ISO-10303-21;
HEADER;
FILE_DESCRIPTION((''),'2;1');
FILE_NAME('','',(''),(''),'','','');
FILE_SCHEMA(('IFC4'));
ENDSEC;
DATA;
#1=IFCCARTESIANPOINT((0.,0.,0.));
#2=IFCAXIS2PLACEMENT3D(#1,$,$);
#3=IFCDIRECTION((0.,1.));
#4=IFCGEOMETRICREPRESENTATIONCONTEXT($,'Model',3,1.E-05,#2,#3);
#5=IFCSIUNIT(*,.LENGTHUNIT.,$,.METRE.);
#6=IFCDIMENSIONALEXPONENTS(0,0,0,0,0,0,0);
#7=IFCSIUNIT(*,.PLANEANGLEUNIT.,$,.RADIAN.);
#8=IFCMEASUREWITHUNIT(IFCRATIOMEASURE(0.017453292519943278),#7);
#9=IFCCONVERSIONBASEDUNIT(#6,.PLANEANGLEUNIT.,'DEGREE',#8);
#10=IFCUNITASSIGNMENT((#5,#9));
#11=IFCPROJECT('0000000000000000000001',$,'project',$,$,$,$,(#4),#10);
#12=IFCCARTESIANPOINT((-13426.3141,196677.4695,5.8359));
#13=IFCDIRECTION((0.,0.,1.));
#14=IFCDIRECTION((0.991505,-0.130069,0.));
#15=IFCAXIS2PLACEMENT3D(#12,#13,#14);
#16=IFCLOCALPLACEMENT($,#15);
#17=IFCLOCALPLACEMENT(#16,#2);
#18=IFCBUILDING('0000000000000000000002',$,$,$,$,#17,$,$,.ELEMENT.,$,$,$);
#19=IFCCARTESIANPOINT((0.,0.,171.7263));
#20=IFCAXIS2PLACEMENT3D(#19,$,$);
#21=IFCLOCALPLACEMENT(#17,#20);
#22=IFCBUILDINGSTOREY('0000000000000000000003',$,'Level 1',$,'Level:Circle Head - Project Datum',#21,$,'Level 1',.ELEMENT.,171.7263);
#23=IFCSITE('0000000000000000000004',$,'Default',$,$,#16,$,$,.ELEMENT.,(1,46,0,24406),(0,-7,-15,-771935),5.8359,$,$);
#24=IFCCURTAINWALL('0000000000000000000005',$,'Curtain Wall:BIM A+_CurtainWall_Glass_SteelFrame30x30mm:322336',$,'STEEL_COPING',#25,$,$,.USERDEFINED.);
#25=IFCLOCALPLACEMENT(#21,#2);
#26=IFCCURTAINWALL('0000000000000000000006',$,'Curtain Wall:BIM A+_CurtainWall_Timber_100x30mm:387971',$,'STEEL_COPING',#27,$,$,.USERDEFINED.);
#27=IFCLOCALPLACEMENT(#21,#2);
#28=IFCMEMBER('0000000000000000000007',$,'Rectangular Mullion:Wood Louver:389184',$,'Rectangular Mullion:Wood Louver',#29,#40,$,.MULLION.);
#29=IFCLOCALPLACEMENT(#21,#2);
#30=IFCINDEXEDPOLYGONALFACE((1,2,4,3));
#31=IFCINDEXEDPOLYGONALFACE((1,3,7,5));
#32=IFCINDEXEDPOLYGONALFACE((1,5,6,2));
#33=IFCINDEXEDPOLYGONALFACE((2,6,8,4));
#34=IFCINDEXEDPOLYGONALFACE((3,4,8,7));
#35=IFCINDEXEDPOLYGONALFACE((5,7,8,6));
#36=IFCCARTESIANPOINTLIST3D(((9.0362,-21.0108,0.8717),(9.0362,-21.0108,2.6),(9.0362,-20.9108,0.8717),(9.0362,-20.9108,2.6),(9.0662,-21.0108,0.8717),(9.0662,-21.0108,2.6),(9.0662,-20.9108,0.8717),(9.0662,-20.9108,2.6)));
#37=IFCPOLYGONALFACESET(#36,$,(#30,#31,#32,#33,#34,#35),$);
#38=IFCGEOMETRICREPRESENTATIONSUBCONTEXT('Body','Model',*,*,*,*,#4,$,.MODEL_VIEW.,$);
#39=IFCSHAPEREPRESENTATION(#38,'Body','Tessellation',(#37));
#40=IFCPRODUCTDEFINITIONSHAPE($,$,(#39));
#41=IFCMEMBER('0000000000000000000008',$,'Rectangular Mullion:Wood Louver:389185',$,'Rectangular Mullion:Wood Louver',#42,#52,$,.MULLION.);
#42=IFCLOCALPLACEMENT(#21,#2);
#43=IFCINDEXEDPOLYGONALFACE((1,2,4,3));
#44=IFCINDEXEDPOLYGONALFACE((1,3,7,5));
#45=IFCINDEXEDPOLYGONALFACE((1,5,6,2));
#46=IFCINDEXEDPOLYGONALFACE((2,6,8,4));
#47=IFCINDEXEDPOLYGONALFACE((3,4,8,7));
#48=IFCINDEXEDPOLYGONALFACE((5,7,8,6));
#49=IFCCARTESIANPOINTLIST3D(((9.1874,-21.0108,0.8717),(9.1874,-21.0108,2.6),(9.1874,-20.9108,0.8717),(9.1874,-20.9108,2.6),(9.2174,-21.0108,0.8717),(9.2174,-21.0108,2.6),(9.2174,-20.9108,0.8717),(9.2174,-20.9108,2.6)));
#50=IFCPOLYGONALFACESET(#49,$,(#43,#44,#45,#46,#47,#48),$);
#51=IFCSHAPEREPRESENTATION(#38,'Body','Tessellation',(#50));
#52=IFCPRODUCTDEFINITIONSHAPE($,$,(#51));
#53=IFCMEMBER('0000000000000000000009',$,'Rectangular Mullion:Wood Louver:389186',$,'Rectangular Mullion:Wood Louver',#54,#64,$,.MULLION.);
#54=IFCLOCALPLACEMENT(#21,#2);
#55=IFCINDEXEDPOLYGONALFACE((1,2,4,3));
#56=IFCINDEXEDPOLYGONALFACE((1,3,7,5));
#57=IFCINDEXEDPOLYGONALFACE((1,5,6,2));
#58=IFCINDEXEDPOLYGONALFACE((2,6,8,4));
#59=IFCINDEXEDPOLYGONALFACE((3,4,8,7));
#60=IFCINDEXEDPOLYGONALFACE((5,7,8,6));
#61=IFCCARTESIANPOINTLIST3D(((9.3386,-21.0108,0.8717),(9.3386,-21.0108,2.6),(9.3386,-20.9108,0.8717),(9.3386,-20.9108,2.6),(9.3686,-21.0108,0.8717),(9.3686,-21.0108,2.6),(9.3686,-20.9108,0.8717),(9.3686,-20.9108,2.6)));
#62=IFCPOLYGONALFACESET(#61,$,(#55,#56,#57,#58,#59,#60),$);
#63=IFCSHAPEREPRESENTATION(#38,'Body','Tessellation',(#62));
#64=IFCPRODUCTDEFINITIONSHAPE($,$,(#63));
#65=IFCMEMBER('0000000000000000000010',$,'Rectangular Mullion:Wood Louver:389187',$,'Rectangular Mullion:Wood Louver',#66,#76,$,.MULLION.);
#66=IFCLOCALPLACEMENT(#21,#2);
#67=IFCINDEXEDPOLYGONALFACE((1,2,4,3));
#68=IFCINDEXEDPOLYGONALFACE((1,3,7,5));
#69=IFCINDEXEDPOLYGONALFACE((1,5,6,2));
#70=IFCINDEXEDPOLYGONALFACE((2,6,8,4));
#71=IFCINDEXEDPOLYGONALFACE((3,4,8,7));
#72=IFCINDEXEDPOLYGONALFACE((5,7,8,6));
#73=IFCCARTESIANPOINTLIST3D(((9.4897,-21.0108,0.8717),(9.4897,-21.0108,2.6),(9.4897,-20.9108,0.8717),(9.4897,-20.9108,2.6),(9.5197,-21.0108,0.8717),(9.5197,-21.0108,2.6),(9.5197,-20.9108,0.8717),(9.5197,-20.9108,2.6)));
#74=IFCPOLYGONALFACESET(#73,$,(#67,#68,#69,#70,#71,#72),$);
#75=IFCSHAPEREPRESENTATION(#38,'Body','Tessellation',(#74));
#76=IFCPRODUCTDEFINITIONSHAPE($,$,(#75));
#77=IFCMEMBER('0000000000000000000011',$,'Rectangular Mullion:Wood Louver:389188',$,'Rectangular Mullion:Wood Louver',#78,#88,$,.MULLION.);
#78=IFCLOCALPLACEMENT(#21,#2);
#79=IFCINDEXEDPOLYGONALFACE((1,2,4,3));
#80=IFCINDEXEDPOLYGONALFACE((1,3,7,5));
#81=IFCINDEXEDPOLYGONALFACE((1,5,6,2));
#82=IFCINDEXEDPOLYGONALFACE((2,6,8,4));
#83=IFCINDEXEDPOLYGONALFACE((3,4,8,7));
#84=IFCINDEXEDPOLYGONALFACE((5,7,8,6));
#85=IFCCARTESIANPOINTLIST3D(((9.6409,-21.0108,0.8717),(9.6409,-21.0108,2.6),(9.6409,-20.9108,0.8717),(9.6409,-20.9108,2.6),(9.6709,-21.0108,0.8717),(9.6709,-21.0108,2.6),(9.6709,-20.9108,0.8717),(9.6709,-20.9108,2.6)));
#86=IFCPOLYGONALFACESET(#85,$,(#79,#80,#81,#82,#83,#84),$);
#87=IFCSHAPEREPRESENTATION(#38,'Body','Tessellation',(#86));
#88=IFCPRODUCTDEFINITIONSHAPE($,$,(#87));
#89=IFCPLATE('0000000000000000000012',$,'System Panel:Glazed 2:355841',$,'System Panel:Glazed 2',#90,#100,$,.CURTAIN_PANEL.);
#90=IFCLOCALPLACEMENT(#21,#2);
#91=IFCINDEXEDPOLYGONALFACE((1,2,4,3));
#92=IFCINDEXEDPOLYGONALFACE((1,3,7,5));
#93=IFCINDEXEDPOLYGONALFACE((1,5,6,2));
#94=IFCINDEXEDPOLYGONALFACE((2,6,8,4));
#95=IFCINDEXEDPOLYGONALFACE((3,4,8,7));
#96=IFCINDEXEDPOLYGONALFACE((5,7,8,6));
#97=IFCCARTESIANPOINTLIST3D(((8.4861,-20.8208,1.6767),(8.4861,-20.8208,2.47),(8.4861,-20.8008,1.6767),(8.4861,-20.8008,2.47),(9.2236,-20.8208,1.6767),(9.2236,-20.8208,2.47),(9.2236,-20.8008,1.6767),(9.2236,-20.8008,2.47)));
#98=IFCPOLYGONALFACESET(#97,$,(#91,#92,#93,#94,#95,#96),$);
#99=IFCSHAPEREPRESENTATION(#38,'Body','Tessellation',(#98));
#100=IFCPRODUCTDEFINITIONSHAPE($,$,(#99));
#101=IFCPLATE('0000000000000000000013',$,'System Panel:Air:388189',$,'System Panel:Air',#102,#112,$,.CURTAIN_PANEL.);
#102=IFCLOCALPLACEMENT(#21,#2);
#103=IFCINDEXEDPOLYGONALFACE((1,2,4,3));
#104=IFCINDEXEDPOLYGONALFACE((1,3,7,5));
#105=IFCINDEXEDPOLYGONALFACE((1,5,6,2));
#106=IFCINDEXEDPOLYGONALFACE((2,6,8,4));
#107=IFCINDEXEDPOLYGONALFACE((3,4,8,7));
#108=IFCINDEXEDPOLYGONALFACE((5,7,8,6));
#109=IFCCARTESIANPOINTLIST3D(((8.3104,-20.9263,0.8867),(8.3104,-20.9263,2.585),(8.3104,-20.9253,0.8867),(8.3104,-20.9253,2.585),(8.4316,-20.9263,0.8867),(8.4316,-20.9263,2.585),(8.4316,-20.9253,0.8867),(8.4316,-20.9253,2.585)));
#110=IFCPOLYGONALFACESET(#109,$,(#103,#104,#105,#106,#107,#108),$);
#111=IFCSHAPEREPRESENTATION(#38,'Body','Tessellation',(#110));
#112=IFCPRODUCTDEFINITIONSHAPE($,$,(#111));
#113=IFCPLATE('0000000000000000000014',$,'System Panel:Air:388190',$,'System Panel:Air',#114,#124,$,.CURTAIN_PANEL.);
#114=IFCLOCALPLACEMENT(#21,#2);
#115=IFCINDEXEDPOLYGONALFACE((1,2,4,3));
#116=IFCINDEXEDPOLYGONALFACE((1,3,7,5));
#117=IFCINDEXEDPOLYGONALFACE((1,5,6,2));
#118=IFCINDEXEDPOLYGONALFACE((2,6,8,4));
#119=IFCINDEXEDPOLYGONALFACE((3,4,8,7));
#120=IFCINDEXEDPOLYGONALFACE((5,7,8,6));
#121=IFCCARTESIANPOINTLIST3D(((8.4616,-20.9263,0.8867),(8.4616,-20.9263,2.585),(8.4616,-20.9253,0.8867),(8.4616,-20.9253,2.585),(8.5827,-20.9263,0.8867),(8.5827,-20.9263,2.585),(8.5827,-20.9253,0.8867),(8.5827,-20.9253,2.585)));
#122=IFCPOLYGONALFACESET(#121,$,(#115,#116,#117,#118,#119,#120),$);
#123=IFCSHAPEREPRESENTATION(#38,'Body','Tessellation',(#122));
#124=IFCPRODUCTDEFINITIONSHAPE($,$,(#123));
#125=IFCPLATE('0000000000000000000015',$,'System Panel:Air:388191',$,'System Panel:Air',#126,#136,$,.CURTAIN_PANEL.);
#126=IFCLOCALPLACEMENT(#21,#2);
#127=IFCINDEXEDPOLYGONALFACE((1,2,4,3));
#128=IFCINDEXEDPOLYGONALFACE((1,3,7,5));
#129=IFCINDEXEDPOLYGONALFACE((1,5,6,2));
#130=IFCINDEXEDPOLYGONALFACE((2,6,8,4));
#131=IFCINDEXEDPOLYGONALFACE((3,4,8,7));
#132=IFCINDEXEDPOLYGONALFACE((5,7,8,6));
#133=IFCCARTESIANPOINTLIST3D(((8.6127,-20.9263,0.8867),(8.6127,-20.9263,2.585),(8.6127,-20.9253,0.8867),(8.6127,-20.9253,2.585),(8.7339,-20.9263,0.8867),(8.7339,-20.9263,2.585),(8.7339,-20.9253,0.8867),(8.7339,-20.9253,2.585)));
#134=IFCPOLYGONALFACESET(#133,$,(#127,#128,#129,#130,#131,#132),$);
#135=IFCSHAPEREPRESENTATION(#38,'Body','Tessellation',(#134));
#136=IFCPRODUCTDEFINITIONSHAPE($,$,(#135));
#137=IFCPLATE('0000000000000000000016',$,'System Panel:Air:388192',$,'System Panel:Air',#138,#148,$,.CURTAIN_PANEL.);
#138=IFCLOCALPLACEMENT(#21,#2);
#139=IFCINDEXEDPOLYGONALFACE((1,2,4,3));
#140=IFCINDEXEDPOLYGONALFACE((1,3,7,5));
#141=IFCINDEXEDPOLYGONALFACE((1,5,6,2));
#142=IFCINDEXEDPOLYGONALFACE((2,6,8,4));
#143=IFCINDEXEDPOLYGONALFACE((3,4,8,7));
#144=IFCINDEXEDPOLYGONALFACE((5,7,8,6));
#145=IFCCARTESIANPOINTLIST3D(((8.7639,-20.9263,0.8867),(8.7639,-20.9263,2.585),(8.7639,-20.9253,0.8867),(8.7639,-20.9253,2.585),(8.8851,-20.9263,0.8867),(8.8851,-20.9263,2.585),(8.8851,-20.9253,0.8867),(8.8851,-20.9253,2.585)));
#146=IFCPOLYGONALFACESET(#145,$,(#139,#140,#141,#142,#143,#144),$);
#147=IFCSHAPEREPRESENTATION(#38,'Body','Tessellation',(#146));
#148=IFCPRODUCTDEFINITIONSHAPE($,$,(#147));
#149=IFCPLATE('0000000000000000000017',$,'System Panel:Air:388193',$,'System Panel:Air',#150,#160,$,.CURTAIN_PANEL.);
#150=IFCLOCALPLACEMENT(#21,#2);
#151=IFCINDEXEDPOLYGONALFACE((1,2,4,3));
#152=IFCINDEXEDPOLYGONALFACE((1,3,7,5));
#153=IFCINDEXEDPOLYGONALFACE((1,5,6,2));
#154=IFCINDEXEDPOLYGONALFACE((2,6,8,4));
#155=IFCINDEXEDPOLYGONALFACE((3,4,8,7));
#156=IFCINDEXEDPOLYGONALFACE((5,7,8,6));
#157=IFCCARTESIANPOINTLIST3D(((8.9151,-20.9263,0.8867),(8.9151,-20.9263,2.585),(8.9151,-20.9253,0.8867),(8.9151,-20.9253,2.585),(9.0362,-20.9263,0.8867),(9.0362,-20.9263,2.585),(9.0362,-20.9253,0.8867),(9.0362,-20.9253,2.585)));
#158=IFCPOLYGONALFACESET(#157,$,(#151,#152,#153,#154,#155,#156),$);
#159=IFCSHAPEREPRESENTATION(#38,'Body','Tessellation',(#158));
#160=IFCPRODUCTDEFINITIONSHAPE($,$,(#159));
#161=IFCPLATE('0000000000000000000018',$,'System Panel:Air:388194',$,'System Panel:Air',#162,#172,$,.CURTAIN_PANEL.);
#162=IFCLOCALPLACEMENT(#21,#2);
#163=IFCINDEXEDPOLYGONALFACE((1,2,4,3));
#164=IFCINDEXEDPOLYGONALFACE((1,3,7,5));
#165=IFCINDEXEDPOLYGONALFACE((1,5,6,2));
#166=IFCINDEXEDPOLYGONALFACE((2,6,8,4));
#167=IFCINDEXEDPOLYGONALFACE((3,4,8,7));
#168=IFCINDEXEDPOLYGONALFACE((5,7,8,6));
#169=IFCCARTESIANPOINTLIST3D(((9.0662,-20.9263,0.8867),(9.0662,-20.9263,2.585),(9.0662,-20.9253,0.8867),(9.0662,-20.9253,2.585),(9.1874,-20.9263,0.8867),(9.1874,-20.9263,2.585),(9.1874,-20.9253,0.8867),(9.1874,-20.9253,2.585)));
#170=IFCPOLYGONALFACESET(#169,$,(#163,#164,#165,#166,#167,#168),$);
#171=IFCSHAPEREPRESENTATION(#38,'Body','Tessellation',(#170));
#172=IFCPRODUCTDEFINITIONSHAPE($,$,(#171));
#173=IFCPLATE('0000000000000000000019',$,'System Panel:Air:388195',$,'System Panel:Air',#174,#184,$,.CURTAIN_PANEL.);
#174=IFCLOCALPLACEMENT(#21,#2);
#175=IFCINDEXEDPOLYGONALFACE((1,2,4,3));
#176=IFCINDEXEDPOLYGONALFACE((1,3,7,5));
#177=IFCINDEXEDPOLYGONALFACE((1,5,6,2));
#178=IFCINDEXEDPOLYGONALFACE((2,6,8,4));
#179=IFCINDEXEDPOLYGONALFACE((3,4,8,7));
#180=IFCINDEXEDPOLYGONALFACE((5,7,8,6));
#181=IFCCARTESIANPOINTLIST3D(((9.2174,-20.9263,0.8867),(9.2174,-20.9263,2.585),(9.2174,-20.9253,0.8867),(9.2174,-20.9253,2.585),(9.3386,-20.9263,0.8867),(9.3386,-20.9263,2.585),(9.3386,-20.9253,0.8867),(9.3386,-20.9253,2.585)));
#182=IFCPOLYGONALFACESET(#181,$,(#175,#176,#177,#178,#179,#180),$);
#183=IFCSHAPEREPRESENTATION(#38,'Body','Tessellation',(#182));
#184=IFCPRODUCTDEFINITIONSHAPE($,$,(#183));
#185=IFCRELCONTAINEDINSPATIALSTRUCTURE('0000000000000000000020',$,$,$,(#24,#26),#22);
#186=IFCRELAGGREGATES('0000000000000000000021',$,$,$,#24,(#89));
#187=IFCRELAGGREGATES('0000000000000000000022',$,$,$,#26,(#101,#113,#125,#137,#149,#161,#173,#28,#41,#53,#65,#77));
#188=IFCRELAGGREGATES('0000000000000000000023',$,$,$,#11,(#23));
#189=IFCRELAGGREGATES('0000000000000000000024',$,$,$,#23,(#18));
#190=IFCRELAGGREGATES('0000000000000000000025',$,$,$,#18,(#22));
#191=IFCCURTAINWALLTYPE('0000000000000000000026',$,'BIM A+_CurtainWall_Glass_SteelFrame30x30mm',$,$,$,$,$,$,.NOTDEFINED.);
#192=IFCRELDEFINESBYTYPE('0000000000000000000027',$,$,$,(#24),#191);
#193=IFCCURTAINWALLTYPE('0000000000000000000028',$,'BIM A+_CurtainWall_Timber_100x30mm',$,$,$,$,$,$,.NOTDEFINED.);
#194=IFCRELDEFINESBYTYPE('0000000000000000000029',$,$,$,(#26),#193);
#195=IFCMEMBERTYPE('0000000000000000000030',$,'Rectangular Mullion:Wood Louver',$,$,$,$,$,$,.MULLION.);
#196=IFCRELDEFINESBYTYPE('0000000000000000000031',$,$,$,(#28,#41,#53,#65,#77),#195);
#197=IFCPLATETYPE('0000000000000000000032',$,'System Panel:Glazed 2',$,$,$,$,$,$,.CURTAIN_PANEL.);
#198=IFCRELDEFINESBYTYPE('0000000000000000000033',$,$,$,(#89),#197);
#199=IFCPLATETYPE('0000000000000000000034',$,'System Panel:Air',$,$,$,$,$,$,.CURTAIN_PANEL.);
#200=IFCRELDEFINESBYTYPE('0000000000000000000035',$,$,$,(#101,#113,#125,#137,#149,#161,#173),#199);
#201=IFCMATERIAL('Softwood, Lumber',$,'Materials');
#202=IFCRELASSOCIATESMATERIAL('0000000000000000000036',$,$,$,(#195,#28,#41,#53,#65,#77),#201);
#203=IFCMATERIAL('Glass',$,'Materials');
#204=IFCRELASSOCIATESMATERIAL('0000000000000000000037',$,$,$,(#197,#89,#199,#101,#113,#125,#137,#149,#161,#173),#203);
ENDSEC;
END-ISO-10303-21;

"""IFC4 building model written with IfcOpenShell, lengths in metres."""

from ifc_helpers import new_model, entity, si_unit, converted_unit, direction, frame, origin, place, context, subcontext, project, spatial, indexed_curve, outline, extrude, source, transform, mapped, material, type_object, type_shapes, element, aggregate, save


model = new_model("IFC4")

# Units and contexts
model_context = context("Model", 3, precision=1e-05, world=origin(), true_north=direction((0.0, 1.0)))
body_context = subcontext(model_context, "Body", "Model", "MODEL_VIEW")
ifc_project = project(units=[si_unit("LENGTHUNIT", "METRE"), converted_unit("PLANEANGLEUNIT", "DEGREE", entity("IfcRatioMeasure", 0.017453292519943278), si_unit("PLANEANGLEUNIT", "RADIAN"), dimensions=[0, 0, 0, 0, 0, 0, 0])], contexts=[model_context])

# Site, building, storey
site_placement = place(None, frame((-13426.3141, 196677.4695, 5.8359), z_axis=(0.0, 0.0, 1.0), x_axis=(0.991505, -0.130069, 0.0)))
site = spatial("IfcSite", under=ifc_project, at=site_placement, Name="Default", CompositionType="ELEMENT", RefLatitude=(1, 46, 0, 24406), RefLongitude=(0, -7, -15, -771935), RefElevation=5.8359)
building_placement = place(site_placement, origin())
building = spatial("IfcBuilding", under=site, at=building_placement, CompositionType="ELEMENT")
storey_placement = place(building_placement, frame((0.0, 0.0, 171.7263)))
storey = spatial("IfcBuildingStorey", under=building, at=storey_placement, Name="Level 1", ObjectType="Level:Circle Head - Project Datum", LongName="Level 1", CompositionType="ELEMENT", Elevation=171.7263)

# Curtain wall
curtain_wall_type_1 = type_object("IfcCurtainWallType", Name="BIM A+_CurtainWall_Glass_SteelFrame30x30mm", PredefinedType="NOTDEFINED")
curtain_wall_1_placement = place(storey_placement, frame((0.0, 0.0, -171.7263)))
curtain_wall_1 = element("IfcCurtainWall", 1, at=curtain_wall_1_placement, inside=storey, type_object=curtain_wall_type_1, Name="Curtain Wall:BIM A+_CurtainWall_Glass_SteelFrame30x30mm:322336", ObjectType="STEEL_COPING", PredefinedType="USERDEFINED")

# Curtain wall, members
curtain_wall_type_2 = type_object("IfcCurtainWallType", Name="BIM A+_CurtainWall_Timber_100x30mm", PredefinedType="NOTDEFINED")
curtain_wall_2_placement = place(storey_placement, frame((0.0, 0.0, -171.7263)))
curtain_wall_2 = element("IfcCurtainWall", 2, at=curtain_wall_2_placement, inside=storey, type_object=curtain_wall_type_2, Name="Curtain Wall:BIM A+_CurtainWall_Timber_100x30mm:387971", ObjectType="STEEL_COPING", PredefinedType="USERDEFINED")
ifc_material_1 = material(Name="Softwood, Lumber", Category="Materials")
member_type_1 = type_object("IfcMemberType", Name="Rectangular Mullion:Wood Louver", PredefinedType="MULLION", material=ifc_material_1)
shared_shape_1 = source(origin(), body_context, "Body", "SweptSolid", [
    extrude(outline(indexed_curve([(-0.05, -0.015), (0.05, -0.015), (0.05, 0.015), (-0.05, 0.015), (-0.05, -0.015)], self_intersect=False)), frame((0.0, 0.035, -1.7283), z_axis=(0.0, 0.0, 1.0), x_axis=(0.0, -1.0, 0.0)), (0.0, 0.0, 1.0), 1.7283),
])
type_shapes(member_type_1, [shared_shape_1])
member_1_placement = place(curtain_wall_2_placement, frame((9.0512, -20.9258, 172.598), z_axis=(0.0, 0.0, -1.0), x_axis=(1.0, 0.0, 0.0)))
member_1 = element("IfcMember", 3, at=member_1_placement, type_object=member_type_1, material=ifc_material_1, Name="Rectangular Mullion:Wood Louver:389184", ObjectType="Rectangular Mullion:Wood Louver", PredefinedType="MULLION", context=body_context, shape_type="MappedRepresentation", body=[
    mapped(shared_shape_1, transform((0.0, 0.0, 0.0), scale=1.0)),
])
member_2_placement = place(curtain_wall_2_placement, frame((9.2024, -20.9258, 172.598), z_axis=(0.0, 0.0, -1.0), x_axis=(1.0, 0.0, 0.0)))
member_2 = element("IfcMember", 4, at=member_2_placement, type_object=member_type_1, material=ifc_material_1, Name="Rectangular Mullion:Wood Louver:389185", ObjectType="Rectangular Mullion:Wood Louver", PredefinedType="MULLION", context=body_context, shape_type="MappedRepresentation", body=[
    mapped(shared_shape_1, transform((0.0, 0.0, 0.0), scale=1.0)),
])
member_3_placement = place(curtain_wall_2_placement, frame((9.3536, -20.9258, 172.598), z_axis=(0.0, 0.0, -1.0), x_axis=(1.0, 0.0, 0.0)))
member_3 = element("IfcMember", 5, at=member_3_placement, type_object=member_type_1, material=ifc_material_1, Name="Rectangular Mullion:Wood Louver:389186", ObjectType="Rectangular Mullion:Wood Louver", PredefinedType="MULLION", context=body_context, shape_type="MappedRepresentation", body=[
    mapped(shared_shape_1, transform((0.0, 0.0, 0.0), scale=1.0)),
])
member_4_placement = place(curtain_wall_2_placement, frame((9.5047, -20.9258, 172.598), z_axis=(0.0, 0.0, -1.0), x_axis=(1.0, 0.0, 0.0)))
member_4 = element("IfcMember", 6, at=member_4_placement, type_object=member_type_1, material=ifc_material_1, Name="Rectangular Mullion:Wood Louver:389187", ObjectType="Rectangular Mullion:Wood Louver", PredefinedType="MULLION", context=body_context, shape_type="MappedRepresentation", body=[
    mapped(shared_shape_1, transform((0.0, 0.0, 0.0), scale=1.0)),
])
member_5_placement = place(curtain_wall_2_placement, frame((9.6559, -20.9258, 172.598), z_axis=(0.0, 0.0, -1.0), x_axis=(1.0, 0.0, 0.0)))
member_5 = element("IfcMember", 7, at=member_5_placement, type_object=member_type_1, material=ifc_material_1, Name="Rectangular Mullion:Wood Louver:389188", ObjectType="Rectangular Mullion:Wood Louver", PredefinedType="MULLION", context=body_context, shape_type="MappedRepresentation", body=[
    mapped(shared_shape_1, transform((0.0, 0.0, 0.0), scale=1.0)),
])

# Plates
ifc_material_2 = material(Name="Glass", Category="Materials")
plate_type_1 = type_object("IfcPlateType", Name="System Panel:Glazed 2", PredefinedType="CURTAIN_PANEL", material=ifc_material_2)
shared_shape_2 = source(origin(), body_context, "Body", "SweptSolid", [
    extrude(outline(indexed_curve([(-0.01, -0.3688), (0.01, -0.3688), (0.01, 0.3688), (-0.01, 0.3688), (-0.01, -0.3688)], self_intersect=False)), frame((0.0, 0.0, 0.0), z_axis=(0.0, 0.0, 1.0), x_axis=(0.0, 1.0, 0.0)), (0.0, 0.0, 1.0), 0.7933),
])
type_shapes(plate_type_1, [shared_shape_2])
plate_1_placement = place(curtain_wall_1_placement, frame((8.8548, -20.8108, 173.4029)))
plate_1 = element("IfcPlate", 8, at=plate_1_placement, type_object=plate_type_1, material=ifc_material_2, Name="System Panel:Glazed 2:355841", ObjectType="System Panel:Glazed 2", PredefinedType="CURTAIN_PANEL", context=body_context, shape_type="MappedRepresentation", body=[
    mapped(shared_shape_2, transform((0.0, 0.0, 0.0), scale=1.0)),
])
aggregate(curtain_wall_1, [plate_1])
plate_type_2 = type_object("IfcPlateType", Name="System Panel:Air", PredefinedType="CURTAIN_PANEL", material=ifc_material_2)
shared_shape_3 = source(origin(), body_context, "Body", "SweptSolid", [
    extrude(outline(indexed_curve([(-0.0005, -0.0606), (0.0005, -0.0606), (0.0005, 0.0606), (-0.0005, 0.0606), (-0.0005, -0.0606)], self_intersect=False)), frame((0.0, 0.0, 0.0), z_axis=(0.0, 0.0, 1.0), x_axis=(0.0, 1.0, 0.0)), (0.0, 0.0, 1.0), 1.6983),
])
type_shapes(plate_type_2, [shared_shape_3])
plate_2_placement = place(curtain_wall_2_placement, frame((8.371, -20.9258, 172.613)))
plate_2 = element("IfcPlate", 9, at=plate_2_placement, type_object=plate_type_2, material=ifc_material_2, Name="System Panel:Air:388189", ObjectType="System Panel:Air", PredefinedType="CURTAIN_PANEL", context=body_context, shape_type="MappedRepresentation", body=[
    mapped(shared_shape_3, transform((0.0, 0.0, 0.0), scale=1.0)),
])
plate_3_placement = place(curtain_wall_2_placement, frame((8.5222, -20.9258, 172.613)))
plate_3 = element("IfcPlate", 10, at=plate_3_placement, type_object=plate_type_2, material=ifc_material_2, Name="System Panel:Air:388190", ObjectType="System Panel:Air", PredefinedType="CURTAIN_PANEL", context=body_context, shape_type="MappedRepresentation", body=[
    mapped(shared_shape_3, transform((0.0, 0.0, 0.0), scale=1.0)),
])
plate_4_placement = place(curtain_wall_2_placement, frame((8.6733, -20.9258, 172.613)))
plate_4 = element("IfcPlate", 11, at=plate_4_placement, type_object=plate_type_2, material=ifc_material_2, Name="System Panel:Air:388191", ObjectType="System Panel:Air", PredefinedType="CURTAIN_PANEL", context=body_context, shape_type="MappedRepresentation", body=[
    mapped(shared_shape_3, transform((0.0, 0.0, 0.0), scale=1.0)),
])
plate_5_placement = place(curtain_wall_2_placement, frame((8.8245, -20.9258, 172.613)))
plate_5 = element("IfcPlate", 12, at=plate_5_placement, type_object=plate_type_2, material=ifc_material_2, Name="System Panel:Air:388192", ObjectType="System Panel:Air", PredefinedType="CURTAIN_PANEL", context=body_context, shape_type="MappedRepresentation", body=[
    mapped(shared_shape_3, transform((0.0, 0.0, 0.0), scale=1.0)),
])
plate_6_placement = place(curtain_wall_2_placement, frame((8.9757, -20.9258, 172.613)))
plate_6 = element("IfcPlate", 13, at=plate_6_placement, type_object=plate_type_2, material=ifc_material_2, Name="System Panel:Air:388193", ObjectType="System Panel:Air", PredefinedType="CURTAIN_PANEL", context=body_context, shape_type="MappedRepresentation", body=[
    mapped(shared_shape_3, transform((0.0, 0.0, 0.0), scale=1.0)),
])
plate_7_placement = place(curtain_wall_2_placement, frame((9.1268, -20.9258, 172.613)))
plate_7 = element("IfcPlate", 14, at=plate_7_placement, type_object=plate_type_2, material=ifc_material_2, Name="System Panel:Air:388194", ObjectType="System Panel:Air", PredefinedType="CURTAIN_PANEL", context=body_context, shape_type="MappedRepresentation", body=[
    mapped(shared_shape_3, transform((0.0, 0.0, 0.0), scale=1.0)),
])
plate_8_placement = place(curtain_wall_2_placement, frame((9.278, -20.9258, 172.613)))
plate_8 = element("IfcPlate", 15, at=plate_8_placement, type_object=plate_type_2, material=ifc_material_2, Name="System Panel:Air:388195", ObjectType="System Panel:Air", PredefinedType="CURTAIN_PANEL", context=body_context, shape_type="MappedRepresentation", body=[
    mapped(shared_shape_3, transform((0.0, 0.0, 0.0), scale=1.0)),
])
aggregate(curtain_wall_2, [plate_2, plate_3, plate_4, plate_5, plate_6, plate_7, plate_8, member_1, member_2, member_3, member_4, member_5])

save(model, "model.ifc")
